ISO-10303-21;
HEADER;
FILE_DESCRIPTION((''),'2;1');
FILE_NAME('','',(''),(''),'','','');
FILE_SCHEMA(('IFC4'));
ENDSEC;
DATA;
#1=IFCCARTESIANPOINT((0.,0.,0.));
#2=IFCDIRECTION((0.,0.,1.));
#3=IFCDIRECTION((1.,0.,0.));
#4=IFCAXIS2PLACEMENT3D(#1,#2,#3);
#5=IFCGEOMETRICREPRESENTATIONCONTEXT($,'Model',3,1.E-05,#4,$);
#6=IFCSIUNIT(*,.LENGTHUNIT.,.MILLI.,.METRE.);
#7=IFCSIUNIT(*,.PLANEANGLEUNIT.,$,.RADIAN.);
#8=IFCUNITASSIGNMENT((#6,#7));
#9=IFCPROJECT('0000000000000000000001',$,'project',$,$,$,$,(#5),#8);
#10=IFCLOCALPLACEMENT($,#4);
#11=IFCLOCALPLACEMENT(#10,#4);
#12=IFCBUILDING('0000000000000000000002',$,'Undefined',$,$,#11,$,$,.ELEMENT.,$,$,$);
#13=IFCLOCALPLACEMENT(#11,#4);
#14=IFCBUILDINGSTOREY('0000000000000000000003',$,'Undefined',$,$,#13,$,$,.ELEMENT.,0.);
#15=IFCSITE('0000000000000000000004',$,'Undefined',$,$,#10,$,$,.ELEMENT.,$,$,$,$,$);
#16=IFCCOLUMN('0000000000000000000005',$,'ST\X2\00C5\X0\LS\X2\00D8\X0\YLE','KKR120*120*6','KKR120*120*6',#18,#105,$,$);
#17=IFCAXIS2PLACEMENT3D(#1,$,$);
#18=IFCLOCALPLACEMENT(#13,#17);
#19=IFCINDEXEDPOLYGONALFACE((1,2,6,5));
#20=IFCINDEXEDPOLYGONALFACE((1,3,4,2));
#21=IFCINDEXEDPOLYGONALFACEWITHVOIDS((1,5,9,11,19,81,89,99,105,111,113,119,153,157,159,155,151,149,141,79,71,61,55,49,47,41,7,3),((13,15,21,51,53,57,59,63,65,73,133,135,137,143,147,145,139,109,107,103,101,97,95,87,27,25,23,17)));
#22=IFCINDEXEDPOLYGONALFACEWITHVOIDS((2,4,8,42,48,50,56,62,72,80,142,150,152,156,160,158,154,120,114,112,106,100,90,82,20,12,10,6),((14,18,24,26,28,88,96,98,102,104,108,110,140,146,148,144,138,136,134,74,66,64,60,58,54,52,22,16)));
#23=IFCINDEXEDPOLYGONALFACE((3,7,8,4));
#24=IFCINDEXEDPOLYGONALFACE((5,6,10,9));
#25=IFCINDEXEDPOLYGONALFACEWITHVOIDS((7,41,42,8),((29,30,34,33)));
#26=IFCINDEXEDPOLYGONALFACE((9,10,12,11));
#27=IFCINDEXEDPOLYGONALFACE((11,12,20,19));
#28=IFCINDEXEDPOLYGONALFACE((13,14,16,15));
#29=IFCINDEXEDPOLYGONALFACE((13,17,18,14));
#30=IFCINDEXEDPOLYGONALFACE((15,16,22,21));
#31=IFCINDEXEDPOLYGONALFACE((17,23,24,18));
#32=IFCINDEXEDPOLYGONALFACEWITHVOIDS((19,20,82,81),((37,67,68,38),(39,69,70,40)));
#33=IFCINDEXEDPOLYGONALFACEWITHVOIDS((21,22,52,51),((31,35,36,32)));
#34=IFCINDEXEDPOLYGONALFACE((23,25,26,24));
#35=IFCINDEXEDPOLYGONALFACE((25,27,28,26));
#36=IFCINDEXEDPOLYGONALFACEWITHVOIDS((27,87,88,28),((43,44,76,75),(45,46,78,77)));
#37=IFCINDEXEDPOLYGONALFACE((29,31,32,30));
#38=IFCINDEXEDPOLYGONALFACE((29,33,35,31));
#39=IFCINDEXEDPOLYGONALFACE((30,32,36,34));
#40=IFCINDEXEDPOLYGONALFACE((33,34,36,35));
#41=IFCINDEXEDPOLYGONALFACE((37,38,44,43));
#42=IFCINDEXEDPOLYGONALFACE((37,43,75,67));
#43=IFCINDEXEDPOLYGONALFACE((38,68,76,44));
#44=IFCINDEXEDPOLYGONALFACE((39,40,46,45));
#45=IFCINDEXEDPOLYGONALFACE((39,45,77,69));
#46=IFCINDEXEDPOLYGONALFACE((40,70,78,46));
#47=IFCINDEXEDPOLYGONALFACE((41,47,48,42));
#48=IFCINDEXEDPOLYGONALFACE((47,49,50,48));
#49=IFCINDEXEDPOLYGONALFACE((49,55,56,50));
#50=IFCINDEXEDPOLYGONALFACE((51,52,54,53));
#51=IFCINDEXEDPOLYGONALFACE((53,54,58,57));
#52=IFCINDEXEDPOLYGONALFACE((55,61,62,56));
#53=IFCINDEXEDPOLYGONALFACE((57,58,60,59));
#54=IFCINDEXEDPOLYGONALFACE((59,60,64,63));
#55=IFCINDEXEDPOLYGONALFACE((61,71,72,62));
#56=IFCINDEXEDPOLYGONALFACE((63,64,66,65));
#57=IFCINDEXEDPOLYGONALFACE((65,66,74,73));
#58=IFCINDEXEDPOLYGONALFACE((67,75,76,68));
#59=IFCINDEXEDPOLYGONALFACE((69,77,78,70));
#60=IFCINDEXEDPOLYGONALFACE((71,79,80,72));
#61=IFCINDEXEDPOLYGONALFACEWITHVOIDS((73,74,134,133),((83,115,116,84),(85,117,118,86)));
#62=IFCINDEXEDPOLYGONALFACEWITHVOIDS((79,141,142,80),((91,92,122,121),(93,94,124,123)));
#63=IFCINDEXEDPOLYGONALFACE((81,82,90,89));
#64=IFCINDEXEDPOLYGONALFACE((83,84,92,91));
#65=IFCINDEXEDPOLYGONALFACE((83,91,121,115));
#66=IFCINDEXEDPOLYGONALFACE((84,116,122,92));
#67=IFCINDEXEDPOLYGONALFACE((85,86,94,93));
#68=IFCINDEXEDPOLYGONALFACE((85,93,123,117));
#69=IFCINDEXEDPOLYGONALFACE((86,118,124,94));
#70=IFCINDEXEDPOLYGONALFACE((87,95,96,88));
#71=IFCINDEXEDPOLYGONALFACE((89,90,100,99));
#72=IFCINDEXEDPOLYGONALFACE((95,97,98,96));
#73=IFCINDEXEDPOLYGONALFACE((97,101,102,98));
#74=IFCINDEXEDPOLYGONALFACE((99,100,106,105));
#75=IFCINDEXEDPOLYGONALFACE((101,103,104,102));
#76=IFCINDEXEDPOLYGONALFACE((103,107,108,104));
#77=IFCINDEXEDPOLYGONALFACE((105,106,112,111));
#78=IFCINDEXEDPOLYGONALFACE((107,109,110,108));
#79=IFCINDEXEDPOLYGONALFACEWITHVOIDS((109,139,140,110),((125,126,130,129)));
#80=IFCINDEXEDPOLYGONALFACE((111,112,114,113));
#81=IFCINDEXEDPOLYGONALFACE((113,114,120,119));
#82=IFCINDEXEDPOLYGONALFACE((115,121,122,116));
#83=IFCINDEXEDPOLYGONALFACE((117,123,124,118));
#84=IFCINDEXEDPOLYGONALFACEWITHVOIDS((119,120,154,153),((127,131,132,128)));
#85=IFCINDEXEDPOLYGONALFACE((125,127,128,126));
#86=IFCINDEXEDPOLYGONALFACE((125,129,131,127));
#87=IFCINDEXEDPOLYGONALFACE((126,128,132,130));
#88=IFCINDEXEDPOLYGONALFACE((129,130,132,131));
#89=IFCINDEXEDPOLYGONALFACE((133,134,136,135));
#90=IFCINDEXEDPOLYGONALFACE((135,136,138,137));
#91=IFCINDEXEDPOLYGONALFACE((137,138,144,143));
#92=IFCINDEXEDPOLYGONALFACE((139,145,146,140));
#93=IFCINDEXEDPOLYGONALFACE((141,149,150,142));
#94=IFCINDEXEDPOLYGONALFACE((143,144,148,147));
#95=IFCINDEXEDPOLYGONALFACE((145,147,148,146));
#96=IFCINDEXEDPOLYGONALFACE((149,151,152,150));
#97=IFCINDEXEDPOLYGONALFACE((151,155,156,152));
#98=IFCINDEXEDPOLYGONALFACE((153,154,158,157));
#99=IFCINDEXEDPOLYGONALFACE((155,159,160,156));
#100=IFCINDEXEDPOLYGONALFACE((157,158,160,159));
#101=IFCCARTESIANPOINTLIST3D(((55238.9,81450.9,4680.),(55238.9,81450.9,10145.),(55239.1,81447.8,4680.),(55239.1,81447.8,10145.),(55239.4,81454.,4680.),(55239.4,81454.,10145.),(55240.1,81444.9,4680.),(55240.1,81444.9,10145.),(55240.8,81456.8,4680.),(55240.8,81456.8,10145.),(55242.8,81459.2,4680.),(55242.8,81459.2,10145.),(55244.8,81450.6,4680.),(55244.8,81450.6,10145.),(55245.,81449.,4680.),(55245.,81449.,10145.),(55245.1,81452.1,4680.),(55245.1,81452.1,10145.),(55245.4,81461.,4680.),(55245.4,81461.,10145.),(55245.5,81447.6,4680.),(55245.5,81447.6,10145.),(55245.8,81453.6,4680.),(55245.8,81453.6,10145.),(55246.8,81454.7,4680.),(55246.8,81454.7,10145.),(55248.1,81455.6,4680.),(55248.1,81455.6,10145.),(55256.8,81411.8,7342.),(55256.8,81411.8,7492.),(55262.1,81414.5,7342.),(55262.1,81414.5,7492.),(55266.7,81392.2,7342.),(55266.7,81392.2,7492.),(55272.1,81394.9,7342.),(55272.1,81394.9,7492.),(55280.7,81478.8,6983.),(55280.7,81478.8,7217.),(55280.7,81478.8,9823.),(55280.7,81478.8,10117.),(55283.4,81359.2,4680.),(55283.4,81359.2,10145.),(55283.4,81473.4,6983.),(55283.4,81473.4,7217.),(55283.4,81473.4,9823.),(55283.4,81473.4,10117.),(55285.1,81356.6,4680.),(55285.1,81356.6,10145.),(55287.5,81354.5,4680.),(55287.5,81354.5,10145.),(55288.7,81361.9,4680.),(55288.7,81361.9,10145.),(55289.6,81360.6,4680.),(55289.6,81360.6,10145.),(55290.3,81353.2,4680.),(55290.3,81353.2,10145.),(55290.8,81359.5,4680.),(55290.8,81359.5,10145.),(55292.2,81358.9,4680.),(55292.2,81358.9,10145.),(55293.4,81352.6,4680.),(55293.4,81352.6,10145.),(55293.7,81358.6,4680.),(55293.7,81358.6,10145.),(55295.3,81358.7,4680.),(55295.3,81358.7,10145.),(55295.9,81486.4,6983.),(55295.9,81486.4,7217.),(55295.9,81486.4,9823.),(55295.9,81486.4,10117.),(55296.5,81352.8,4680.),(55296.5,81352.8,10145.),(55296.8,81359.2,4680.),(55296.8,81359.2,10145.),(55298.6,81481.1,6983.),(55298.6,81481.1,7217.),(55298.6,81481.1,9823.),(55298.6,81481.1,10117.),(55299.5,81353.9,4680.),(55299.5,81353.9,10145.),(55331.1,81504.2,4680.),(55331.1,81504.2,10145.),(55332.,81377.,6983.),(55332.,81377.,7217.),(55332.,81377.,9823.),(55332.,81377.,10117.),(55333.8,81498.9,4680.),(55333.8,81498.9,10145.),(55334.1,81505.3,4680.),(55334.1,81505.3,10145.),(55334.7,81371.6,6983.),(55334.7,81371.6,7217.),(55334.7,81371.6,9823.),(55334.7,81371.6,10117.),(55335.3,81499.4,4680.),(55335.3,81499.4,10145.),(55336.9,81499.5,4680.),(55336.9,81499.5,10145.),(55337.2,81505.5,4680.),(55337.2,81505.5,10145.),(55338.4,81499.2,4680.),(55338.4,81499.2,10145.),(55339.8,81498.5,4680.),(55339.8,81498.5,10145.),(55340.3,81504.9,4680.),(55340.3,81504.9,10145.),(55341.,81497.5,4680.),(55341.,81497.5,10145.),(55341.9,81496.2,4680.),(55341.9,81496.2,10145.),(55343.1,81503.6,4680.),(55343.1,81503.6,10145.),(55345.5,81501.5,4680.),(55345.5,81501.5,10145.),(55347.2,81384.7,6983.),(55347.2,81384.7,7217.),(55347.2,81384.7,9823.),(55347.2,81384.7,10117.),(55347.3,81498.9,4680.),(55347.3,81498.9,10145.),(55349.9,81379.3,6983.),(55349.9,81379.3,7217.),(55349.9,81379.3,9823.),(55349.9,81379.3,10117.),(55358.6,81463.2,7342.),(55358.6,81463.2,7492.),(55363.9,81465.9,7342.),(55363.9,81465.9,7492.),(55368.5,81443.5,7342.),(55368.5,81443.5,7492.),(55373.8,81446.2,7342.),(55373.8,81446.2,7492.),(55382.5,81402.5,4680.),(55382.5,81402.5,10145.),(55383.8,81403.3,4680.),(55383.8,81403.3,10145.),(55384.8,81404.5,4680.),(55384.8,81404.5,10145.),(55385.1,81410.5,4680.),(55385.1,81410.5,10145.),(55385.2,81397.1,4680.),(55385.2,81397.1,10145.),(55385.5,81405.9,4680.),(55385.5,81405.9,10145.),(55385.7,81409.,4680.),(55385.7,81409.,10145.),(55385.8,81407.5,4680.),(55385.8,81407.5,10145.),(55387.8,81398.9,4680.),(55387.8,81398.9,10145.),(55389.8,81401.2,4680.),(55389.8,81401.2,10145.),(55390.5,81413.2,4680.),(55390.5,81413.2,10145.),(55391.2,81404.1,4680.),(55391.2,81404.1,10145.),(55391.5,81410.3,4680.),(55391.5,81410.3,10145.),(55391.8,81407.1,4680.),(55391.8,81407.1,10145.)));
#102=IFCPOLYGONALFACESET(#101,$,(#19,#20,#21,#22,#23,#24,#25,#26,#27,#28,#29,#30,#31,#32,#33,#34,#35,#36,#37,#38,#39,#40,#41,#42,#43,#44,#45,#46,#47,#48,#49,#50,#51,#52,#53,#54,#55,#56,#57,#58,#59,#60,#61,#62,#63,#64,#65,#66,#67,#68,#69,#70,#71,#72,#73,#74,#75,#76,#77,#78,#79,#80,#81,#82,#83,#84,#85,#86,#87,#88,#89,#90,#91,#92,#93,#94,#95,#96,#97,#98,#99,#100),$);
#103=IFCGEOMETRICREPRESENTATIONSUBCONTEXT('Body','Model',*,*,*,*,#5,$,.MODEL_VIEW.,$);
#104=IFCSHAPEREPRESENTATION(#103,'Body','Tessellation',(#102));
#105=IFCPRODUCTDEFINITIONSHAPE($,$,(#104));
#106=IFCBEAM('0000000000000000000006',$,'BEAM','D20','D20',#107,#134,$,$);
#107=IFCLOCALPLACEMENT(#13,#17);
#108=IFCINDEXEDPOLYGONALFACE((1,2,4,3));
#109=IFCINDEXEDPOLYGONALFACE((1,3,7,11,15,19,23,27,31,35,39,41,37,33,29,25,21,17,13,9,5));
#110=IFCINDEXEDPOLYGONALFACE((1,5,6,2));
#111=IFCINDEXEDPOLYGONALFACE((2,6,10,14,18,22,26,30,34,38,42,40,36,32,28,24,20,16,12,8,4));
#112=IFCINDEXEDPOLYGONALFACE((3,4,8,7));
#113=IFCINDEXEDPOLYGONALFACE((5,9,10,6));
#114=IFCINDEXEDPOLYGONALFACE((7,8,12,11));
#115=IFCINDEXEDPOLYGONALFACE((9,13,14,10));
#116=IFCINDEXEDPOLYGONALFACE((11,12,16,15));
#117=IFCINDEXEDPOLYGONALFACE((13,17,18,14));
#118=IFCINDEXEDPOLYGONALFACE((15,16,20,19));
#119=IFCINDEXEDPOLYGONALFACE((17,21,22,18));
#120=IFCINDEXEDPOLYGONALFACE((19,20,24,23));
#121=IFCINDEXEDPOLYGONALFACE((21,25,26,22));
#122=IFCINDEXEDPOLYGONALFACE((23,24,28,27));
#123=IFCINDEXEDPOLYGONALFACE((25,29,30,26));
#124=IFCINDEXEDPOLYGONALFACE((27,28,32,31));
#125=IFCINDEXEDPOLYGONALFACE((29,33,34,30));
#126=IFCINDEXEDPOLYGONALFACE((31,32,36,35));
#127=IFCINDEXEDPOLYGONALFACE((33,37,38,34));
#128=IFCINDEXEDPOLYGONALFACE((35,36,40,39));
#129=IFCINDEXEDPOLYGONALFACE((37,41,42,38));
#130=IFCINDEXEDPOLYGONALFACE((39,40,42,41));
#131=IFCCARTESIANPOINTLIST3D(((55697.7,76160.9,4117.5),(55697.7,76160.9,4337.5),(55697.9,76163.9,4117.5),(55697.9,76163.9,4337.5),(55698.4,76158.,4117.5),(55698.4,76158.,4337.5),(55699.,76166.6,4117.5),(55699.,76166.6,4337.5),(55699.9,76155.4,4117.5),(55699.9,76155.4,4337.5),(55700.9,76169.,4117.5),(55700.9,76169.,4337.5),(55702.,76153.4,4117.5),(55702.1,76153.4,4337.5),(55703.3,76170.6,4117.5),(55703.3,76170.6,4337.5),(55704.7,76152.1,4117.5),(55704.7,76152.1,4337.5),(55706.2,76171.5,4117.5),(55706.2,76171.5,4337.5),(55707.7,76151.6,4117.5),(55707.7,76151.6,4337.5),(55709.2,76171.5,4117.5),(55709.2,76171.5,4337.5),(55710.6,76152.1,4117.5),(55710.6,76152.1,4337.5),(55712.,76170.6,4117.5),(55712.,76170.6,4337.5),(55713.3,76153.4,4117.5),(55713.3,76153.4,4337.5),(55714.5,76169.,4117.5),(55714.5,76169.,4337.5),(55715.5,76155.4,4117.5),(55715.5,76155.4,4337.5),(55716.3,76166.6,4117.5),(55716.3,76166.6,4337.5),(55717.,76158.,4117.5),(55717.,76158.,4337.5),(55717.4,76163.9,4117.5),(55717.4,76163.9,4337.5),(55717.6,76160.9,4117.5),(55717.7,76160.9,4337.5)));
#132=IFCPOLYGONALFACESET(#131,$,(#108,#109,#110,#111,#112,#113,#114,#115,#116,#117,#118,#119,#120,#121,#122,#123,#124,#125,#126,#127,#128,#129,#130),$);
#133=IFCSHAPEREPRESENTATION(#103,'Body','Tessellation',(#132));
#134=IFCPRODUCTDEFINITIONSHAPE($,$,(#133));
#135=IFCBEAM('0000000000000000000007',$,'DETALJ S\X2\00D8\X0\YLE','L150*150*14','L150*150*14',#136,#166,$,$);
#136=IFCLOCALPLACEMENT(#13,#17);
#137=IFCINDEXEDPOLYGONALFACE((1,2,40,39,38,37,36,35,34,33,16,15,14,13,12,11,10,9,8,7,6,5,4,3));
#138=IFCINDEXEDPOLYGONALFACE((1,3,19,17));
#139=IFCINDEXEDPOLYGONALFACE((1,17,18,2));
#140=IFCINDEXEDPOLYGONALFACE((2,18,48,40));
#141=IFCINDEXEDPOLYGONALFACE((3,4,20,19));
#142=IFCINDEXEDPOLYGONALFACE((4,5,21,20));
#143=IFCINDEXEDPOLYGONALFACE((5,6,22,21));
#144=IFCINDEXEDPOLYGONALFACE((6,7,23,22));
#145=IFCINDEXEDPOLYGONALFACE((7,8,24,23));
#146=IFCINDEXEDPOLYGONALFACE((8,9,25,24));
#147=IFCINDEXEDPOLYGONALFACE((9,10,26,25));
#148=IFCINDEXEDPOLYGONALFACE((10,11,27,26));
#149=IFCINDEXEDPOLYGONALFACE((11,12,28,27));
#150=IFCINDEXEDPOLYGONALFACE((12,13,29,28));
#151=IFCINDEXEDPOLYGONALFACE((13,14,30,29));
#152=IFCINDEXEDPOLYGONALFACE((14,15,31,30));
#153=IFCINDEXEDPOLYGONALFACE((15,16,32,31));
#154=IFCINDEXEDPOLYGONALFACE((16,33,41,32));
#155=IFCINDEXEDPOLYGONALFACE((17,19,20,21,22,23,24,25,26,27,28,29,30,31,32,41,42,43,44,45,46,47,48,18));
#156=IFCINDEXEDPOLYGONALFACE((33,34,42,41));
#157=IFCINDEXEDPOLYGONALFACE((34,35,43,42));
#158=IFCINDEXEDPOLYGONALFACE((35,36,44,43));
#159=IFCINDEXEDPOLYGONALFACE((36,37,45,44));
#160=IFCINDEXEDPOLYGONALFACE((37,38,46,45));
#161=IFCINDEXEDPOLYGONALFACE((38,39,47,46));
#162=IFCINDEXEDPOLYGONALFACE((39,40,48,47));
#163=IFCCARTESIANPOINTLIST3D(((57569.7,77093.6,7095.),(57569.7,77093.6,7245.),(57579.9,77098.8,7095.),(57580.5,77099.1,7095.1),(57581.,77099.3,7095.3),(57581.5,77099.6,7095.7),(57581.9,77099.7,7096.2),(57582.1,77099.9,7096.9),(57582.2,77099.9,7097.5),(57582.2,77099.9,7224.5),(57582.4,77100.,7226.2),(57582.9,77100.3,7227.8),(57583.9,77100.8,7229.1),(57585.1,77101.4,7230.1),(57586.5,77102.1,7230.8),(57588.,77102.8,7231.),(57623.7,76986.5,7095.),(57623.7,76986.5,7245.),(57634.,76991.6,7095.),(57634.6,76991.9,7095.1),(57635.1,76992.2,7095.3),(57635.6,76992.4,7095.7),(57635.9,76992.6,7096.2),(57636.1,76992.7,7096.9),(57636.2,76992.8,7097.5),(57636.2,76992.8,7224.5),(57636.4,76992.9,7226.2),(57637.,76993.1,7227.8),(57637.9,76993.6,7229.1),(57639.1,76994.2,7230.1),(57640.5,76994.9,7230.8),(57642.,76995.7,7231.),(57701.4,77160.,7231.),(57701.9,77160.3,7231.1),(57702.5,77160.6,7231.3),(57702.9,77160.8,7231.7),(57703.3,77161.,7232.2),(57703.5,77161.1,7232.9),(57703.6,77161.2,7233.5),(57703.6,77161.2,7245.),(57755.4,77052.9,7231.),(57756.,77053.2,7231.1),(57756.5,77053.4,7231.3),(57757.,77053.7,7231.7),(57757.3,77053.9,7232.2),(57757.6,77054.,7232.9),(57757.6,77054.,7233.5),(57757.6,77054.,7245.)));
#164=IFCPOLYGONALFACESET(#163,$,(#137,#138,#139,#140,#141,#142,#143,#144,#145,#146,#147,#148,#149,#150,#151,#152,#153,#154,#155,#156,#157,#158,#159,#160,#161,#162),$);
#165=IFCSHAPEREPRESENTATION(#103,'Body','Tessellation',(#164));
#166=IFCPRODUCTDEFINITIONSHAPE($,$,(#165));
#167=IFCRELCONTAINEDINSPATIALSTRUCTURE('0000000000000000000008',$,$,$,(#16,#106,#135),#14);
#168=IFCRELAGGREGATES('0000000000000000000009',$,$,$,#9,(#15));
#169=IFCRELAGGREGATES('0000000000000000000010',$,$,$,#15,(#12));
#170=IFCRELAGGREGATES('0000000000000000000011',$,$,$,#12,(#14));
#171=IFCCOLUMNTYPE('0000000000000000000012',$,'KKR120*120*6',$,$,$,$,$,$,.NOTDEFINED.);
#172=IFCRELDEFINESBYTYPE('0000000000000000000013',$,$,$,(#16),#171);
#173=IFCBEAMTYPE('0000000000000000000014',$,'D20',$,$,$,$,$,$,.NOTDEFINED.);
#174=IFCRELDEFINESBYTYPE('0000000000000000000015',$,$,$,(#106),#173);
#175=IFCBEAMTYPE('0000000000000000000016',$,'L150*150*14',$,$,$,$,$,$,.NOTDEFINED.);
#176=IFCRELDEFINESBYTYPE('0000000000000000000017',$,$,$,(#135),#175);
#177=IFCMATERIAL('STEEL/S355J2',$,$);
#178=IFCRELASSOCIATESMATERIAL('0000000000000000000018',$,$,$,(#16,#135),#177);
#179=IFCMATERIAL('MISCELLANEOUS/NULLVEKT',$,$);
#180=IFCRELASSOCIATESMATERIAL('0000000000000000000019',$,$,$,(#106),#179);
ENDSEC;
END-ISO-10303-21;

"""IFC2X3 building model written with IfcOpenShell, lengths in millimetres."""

from ifc_helpers import new_model, si_unit, frame, origin_with_axes, origin_2d_with_axis, place, context, subcontext, project, spatial, polyline, hollow_rectangle, circle, l_section, outline, extrude, boolean, halfspace, material, type_object, element, save


model = new_model("IFC2X3")

# Units and contexts
model_context = context("Model", 3, precision=1e-05, world=origin_with_axes())
body_context = subcontext(model_context, "Body", "Model", "MODEL_VIEW")
ifc_project = project(units=[si_unit("LENGTHUNIT", "METRE", prefix="MILLI"), si_unit("PLANEANGLEUNIT", "RADIAN")], contexts=[model_context])

# Site, building, storey
site_placement = place(None, origin_with_axes())
site = spatial("IfcSite", under=ifc_project, at=site_placement, Name="Undefined", CompositionType="ELEMENT")
building_placement = place(site_placement, origin_with_axes())
building = spatial("IfcBuilding", under=site, at=building_placement, Name="Undefined", CompositionType="ELEMENT")
storey_placement = place(building_placement, origin_with_axes())
storey = spatial("IfcBuildingStorey", under=building, at=storey_placement, Name="Undefined", CompositionType="ELEMENT", Elevation=0.0)

# Column
ifc_material_1 = material(Name="STEEL/S355J2")
column_type_1 = type_object("IfcColumnType", Name="KKR120*120*6", PredefinedType="NOTDEFINED")
column_1_placement = place(storey_placement, frame((55315.3, 81429.0, 4680.0), z_axis=(0.0, 0.0, 1.0), x_axis=(-0.450512, 0.89277, 0.0)))
element("IfcColumn", 1, at=column_1_placement, inside=storey, type_object=column_type_1, material=ifc_material_1, Name="STÅLSØYLE", Description="KKR120*120*6", ObjectType="KKR120*120*6", context=body_context, shape_type="CSG", body=[
    boolean("DIFFERENCE", boolean("DIFFERENCE", boolean("DIFFERENCE", boolean("DIFFERENCE", boolean("DIFFERENCE", boolean("DIFFERENCE", extrude(hollow_rectangle(XDim=120.0, YDim=120.0, WallThickness=6.0, InnerFilletRadius=6.0, OuterFilletRadius=12.0, at=origin_2d_with_axis()), frame((0.0, 0.0, 5465.0), z_axis=(0.0, 0.0, -1.0), x_axis=(0.0, 1.0, 0.0)), (0.0, 0.0, 1.0), 5465.0), extrude(outline(polyline([(0.0, 0.0), (245.0, 0.0), (245.0, 150.0), (0.0, 150.0), (0.0, 0.0)])), frame((11.0, -70.0, 2812.0), z_axis=(-1.0, 0.000114, 0.0), x_axis=(0.000114, 1.0, 0.0)), (0.0, 0.0, 1.0), 22.0)), extrude(outline(polyline([(0.0, 0.0), (17.0, 0.0), (17.0, 234.0), (0.0, 234.0), (0.0, 0.0)])), frame((44.0, 8.5, 2537.0), z_axis=(1.0, -0.000113, 0.0), x_axis=(-0.000113, -1.0, 0.0)), (0.0, 0.0, 1.0), 26.0)), extrude(outline(polyline([(0.0, 0.0), (17.0, 0.0), (17.0, 234.0), (0.0, 234.0), (0.0, 0.0)])), frame((-70.0, 8.5, 2537.0), z_axis=(1.0, -0.000113, 0.0), x_axis=(-0.000113, -1.0, 0.0)), (0.0, 0.0, 1.0), 26.0)), extrude(outline(polyline([(0.0, 0.0), (17.0, 0.0), (17.0, 294.0), (0.0, 294.0), (0.0, 0.0)])), frame((44.0, 8.5, 5437.0), z_axis=(1.0, -0.000113, 0.0), x_axis=(-0.000113, -1.0, 0.0)), (0.0, 0.0, 1.0), 26.0)), extrude(outline(polyline([(0.0, 0.0), (17.0, 0.0), (17.0, 294.0), (0.0, 294.0), (0.0, 0.0)])), frame((-70.0, 8.5, 5437.0), z_axis=(1.0, -0.000113, 0.0), x_axis=(-0.000113, -1.0, 0.0)), (0.0, 0.0, 1.0), 26.0)), halfspace(frame((-60.0, 0.0, 5465.0), z_axis=(0.0, 0.0, -1.0), x_axis=(0.0, -1.0, 0.0)), True)),
])

# Beams
ifc_material_2 = material(Name="MISCELLANEOUS/NULLVEKT")
beam_type_1 = type_object("IfcBeamType", Name="D20", PredefinedType="NOTDEFINED")
beam_1_placement = place(storey_placement, frame((55707.7, 76161.6, 4337.5), z_axis=(1.0, 0.0, -0.000032), x_axis=(-0.000032, 0.000048, -1.0)))
element("IfcBeam", 2, at=beam_1_placement, inside=storey, type_object=beam_type_1, material=ifc_material_2, Name="BEAM", Description="D20", ObjectType="D20", context=body_context, shape_type="SweptSolid", body=[
    extrude(circle(Radius=10.0, at=origin_2d_with_axis()), frame((220.0, 0.0, 0.0), z_axis=(-1.0, 0.0, 0.0), x_axis=(0.0, -1.0, 0.0)), (0.0, 0.0, 1.0), 220.0),
])
beam_type_2 = type_object("IfcBeamType", Name="L150*150*14", PredefinedType="NOTDEFINED")
for number, where, z_axis, x_axis, name in (
    (3, (57690.7, 77020.2, 7170.0), (0.892826, 0.450402, 0.0), (-0.450402, 0.892826, 0.0), "DETALJ SØYLE"),
):
    element("IfcBeam", number, at=place(storey_placement, frame(where, z_axis=z_axis, x_axis=x_axis)), inside=storey, type_object=beam_type_2, material=ifc_material_1, Name=name, Description="L150*150*14", ObjectType="L150*150*14", context=body_context, shape_type="SweptSolid", body=[
        extrude(l_section(Depth=150.0, Width=150.0, Thickness=14.0, FilletRadius=6.5, EdgeRadius=2.5, at=origin_2d_with_axis()), frame((120.0, 0.0, 0.0), z_axis=(-1.0, 0.0, 0.0), x_axis=(0.0, -1.0, 0.0)), (0.0, 0.0, 1.0), 120.0),
    ])

save(model, "model.ifc")
